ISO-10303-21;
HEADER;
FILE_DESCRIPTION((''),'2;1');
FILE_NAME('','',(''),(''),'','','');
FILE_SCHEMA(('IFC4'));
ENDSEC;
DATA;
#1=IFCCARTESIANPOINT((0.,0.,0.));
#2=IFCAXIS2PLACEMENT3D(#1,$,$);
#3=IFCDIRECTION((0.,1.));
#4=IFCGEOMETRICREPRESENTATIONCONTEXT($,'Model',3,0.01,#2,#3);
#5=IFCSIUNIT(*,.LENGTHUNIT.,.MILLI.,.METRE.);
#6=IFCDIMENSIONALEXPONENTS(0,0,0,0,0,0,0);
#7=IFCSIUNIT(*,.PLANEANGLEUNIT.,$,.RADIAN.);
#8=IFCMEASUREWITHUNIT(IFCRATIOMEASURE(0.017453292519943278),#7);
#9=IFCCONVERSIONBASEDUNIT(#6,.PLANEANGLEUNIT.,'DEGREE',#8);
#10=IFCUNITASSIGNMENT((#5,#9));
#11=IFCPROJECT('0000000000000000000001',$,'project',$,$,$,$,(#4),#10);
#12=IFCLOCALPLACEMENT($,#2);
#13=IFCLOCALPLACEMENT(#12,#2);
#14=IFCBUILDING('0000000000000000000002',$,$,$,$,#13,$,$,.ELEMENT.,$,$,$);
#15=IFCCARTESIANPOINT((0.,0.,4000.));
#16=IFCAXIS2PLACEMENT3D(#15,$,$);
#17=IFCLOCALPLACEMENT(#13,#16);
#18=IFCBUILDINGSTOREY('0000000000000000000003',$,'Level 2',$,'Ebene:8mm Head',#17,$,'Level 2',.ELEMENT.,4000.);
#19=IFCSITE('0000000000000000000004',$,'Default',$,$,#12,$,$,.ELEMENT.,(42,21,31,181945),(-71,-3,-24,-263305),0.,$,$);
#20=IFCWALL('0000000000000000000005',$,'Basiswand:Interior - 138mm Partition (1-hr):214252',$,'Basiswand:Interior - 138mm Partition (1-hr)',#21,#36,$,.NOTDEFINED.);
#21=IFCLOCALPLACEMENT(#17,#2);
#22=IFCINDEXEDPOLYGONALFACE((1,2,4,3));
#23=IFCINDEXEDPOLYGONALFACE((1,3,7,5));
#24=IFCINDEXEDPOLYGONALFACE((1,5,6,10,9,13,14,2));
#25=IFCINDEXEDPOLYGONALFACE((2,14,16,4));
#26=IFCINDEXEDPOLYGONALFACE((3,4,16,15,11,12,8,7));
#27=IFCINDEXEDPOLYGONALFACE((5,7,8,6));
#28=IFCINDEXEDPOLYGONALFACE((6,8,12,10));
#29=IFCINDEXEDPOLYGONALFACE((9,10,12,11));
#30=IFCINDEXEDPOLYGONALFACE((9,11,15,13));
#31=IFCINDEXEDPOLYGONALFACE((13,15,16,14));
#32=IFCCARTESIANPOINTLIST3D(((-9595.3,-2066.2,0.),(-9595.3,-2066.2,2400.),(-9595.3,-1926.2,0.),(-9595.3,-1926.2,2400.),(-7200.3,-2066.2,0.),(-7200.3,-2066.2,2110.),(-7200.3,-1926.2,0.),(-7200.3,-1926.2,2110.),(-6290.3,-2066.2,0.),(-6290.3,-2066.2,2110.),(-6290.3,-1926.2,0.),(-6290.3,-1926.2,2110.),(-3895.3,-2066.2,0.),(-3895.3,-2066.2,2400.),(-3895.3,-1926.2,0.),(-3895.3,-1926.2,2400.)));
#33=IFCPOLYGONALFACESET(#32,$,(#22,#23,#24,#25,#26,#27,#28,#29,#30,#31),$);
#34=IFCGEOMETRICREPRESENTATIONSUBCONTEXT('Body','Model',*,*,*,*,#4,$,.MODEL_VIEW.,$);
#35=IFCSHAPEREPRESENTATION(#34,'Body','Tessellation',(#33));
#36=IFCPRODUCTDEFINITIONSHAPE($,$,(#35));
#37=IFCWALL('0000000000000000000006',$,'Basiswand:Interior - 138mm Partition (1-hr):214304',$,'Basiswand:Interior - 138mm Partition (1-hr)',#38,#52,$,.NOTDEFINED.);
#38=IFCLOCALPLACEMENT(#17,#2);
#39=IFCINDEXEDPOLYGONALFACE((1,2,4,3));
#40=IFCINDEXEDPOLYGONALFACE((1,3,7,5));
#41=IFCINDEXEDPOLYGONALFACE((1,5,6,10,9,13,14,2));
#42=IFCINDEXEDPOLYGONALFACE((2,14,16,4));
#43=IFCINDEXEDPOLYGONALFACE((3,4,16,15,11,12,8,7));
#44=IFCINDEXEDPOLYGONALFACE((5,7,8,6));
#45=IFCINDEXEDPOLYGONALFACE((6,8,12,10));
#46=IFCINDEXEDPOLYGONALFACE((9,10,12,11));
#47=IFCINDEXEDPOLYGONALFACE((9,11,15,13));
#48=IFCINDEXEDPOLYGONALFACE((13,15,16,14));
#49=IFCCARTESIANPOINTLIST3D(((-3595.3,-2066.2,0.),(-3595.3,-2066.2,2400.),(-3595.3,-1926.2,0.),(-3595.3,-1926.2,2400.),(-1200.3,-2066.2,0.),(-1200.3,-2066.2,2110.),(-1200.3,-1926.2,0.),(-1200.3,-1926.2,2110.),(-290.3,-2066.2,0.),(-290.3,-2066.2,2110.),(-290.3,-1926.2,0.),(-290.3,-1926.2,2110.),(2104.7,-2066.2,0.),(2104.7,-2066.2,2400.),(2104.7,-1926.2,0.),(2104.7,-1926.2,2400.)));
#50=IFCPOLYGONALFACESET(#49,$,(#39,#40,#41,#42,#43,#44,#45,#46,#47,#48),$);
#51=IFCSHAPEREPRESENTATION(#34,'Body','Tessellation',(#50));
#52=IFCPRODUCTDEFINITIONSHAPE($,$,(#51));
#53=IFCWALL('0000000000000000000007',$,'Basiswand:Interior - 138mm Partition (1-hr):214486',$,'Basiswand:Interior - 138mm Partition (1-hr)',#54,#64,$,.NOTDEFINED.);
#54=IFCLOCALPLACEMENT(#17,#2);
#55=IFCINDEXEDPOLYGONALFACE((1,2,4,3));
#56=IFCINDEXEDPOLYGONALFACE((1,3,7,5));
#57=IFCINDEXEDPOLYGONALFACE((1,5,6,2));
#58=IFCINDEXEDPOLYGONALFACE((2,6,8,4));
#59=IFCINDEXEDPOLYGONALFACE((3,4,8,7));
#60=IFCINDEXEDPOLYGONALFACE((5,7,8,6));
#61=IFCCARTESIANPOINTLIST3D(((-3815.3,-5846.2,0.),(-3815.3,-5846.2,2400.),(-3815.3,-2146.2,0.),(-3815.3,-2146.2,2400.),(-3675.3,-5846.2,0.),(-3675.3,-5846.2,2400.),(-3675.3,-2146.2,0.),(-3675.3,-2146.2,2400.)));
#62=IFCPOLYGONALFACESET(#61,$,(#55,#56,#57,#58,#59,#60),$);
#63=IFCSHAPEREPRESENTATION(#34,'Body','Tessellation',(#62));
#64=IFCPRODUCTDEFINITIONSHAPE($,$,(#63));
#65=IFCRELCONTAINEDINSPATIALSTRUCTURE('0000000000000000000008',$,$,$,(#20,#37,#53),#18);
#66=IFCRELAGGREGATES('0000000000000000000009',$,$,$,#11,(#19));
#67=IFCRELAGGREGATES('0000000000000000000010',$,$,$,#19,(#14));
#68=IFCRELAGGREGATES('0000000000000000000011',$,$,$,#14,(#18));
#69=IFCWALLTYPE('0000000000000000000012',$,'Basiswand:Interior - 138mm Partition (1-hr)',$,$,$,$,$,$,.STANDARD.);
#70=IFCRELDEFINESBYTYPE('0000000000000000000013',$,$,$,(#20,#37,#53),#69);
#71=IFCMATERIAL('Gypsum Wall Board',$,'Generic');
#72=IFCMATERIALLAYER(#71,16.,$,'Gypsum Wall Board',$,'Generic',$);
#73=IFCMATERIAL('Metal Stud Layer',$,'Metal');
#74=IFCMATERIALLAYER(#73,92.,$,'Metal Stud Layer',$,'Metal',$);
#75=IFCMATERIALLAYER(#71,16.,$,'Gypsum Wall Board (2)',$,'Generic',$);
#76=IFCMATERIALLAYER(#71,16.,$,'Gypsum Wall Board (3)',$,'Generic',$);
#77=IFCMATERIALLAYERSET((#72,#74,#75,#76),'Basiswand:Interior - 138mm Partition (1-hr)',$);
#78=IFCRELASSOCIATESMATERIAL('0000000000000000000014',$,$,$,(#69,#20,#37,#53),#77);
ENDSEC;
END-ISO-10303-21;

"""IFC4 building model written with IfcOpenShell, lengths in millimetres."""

from ifc_helpers import new_model, entity, si_unit, converted_unit, direction, frame, frame_2d, origin, place, context, subcontext, project, spatial, rectangle, extrude, material, layer, layer_set, layer_usage, type_object, element, save


model = new_model("IFC4")

# Units and contexts
model_context = context("Model", 3, precision=0.01, world=origin(), true_north=direction((0.0, 1.0)))
body_context = subcontext(model_context, "Body", "Model", "MODEL_VIEW")
ifc_project = project(units=[si_unit("LENGTHUNIT", "METRE", prefix="MILLI"), converted_unit("PLANEANGLEUNIT", "DEGREE", entity("IfcRatioMeasure", 0.017453292519943278), si_unit("PLANEANGLEUNIT", "RADIAN"), dimensions=[0, 0, 0, 0, 0, 0, 0])], contexts=[model_context])

# Site, building, storey
site_placement = place(None, origin())
site = spatial("IfcSite", under=ifc_project, at=site_placement, Name="Default", CompositionType="ELEMENT", RefLatitude=(42, 21, 31, 181945), RefLongitude=(-71, -3, -24, -263305), RefElevation=0.0)
building_placement = place(site_placement, origin())
building = spatial("IfcBuilding", under=site, at=building_placement, CompositionType="ELEMENT")
storey_placement = place(building_placement, frame((0.0, 0.0, 4000.0)))
storey = spatial("IfcBuildingStorey", under=building, at=storey_placement, Name="Level 2", ObjectType="Ebene:8mm Head", LongName="Level 2", CompositionType="ELEMENT", Elevation=4000.0)

# Shared definitions
ifc_material_1 = material(Name="Gypsum Wall Board", Category="Generic")
ifc_layer_1 = layer(ifc_material_1, 16.0, Name="Gypsum Wall Board", Category="Generic")
ifc_material_2 = material(Name="Metal Stud Layer", Category="Metal")
ifc_layer_2 = layer(ifc_material_2, 92.0, Name="Metal Stud Layer", Category="Metal")
ifc_layer_3 = layer(ifc_material_1, 16.0, Name="Gypsum Wall Board (2)", Category="Generic")
ifc_layer_4 = layer(ifc_material_1, 16.0, Name="Gypsum Wall Board (3)", Category="Generic")
ifc_layer_set_1 = layer_set([ifc_layer_1, ifc_layer_2, ifc_layer_3, ifc_layer_4], Name="Basiswand:Interior - 138mm Partition (1-hr)")
wall_type_1 = type_object("IfcWallType", Name="Basiswand:Interior - 138mm Partition (1-hr)", PredefinedType="STANDARD", material=ifc_layer_set_1)

# Walls, openings
ifc_layer_usage_1 = layer_usage(ifc_layer_set_1, "AXIS2", "NEGATIVE", 70.0)
wall_1_placement = place(storey_placement, frame((-9595.3, -1996.2, 0.0)))
wall_1 = element("IfcWall", 1, at=wall_1_placement, inside=storey, type_object=wall_type_1, material=ifc_layer_usage_1, Name="Basiswand:Interior - 138mm Partition (1-hr):214252", ObjectType="Basiswand:Interior - 138mm Partition (1-hr)", PredefinedType="NOTDEFINED", context=body_context, shape_type="SweptSolid", body=[
    extrude(rectangle(XDim=5700.0, YDim=140.0, at=frame_2d((2850.0, 0.0), x_axis=(1.0, 0.0))), origin(), (0.0, 0.0, 1.0), 2400.0),
])
opening_1_placement = place(wall_1_placement, frame((3305.0, 70.0, 0.0)))
element("IfcOpeningElement", 2, at=opening_1_placement, cuts=wall_1, PredefinedType="OPENING", context=body_context, shape_type="SweptSolid", body=[
    extrude(rectangle(XDim=2110.0, YDim=910.0, at=frame_2d((1055.0, 455.0), x_axis=(1.0, 0.0))), frame((0.0, 0.0, 0.0), z_axis=(0.0, -1.0, 0.0), x_axis=(0.0, 0.0, 1.0)), (0.0, 0.0, 1.0), 140.0),
])
ifc_layer_usage_2 = layer_usage(ifc_layer_set_1, "AXIS2", "NEGATIVE", 70.0)
wall_2_placement = place(storey_placement, frame((-3595.3, -1996.2, 0.0)))
wall_2 = element("IfcWall", 3, at=wall_2_placement, inside=storey, type_object=wall_type_1, material=ifc_layer_usage_2, Name="Basiswand:Interior - 138mm Partition (1-hr):214304", ObjectType="Basiswand:Interior - 138mm Partition (1-hr)", PredefinedType="NOTDEFINED", context=body_context, shape_type="SweptSolid", body=[
    extrude(rectangle(XDim=5700.0, YDim=140.0, at=frame_2d((2850.0, 0.0), x_axis=(1.0, 0.0))), origin(), (0.0, 0.0, 1.0), 2400.0),
])
opening_2_placement = place(wall_2_placement, frame((3305.0, 70.0, 0.0)))
element("IfcOpeningElement", 4, at=opening_2_placement, cuts=wall_2, PredefinedType="OPENING", context=body_context, shape_type="SweptSolid", body=[
    extrude(rectangle(XDim=2110.0, YDim=910.0, at=frame_2d((1055.0, 455.0), x_axis=(1.0, 0.0))), frame((0.0, 0.0, 0.0), z_axis=(0.0, -1.0, 0.0), x_axis=(0.0, 0.0, 1.0)), (0.0, 0.0, 1.0), 140.0),
])

# Wall
ifc_layer_usage_3 = layer_usage(ifc_layer_set_1, "AXIS2", "NEGATIVE", 70.0)
wall_3_placement = place(storey_placement, frame((-3745.3, -2146.2, 0.0), z_axis=(0.0, 0.0, 1.0), x_axis=(0.0, -1.0, 0.0)))
element("IfcWall", 5, at=wall_3_placement, inside=storey, type_object=wall_type_1, material=ifc_layer_usage_3, Name="Basiswand:Interior - 138mm Partition (1-hr):214486", ObjectType="Basiswand:Interior - 138mm Partition (1-hr)", PredefinedType="NOTDEFINED", context=body_context, shape_type="SweptSolid", body=[
    extrude(rectangle(XDim=3700.0, YDim=140.0, at=frame_2d((1850.0, 0.0), x_axis=(-1.0, 0.0))), origin(), (0.0, 0.0, 1.0), 2400.0),
])

save(model, "model.ifc")
